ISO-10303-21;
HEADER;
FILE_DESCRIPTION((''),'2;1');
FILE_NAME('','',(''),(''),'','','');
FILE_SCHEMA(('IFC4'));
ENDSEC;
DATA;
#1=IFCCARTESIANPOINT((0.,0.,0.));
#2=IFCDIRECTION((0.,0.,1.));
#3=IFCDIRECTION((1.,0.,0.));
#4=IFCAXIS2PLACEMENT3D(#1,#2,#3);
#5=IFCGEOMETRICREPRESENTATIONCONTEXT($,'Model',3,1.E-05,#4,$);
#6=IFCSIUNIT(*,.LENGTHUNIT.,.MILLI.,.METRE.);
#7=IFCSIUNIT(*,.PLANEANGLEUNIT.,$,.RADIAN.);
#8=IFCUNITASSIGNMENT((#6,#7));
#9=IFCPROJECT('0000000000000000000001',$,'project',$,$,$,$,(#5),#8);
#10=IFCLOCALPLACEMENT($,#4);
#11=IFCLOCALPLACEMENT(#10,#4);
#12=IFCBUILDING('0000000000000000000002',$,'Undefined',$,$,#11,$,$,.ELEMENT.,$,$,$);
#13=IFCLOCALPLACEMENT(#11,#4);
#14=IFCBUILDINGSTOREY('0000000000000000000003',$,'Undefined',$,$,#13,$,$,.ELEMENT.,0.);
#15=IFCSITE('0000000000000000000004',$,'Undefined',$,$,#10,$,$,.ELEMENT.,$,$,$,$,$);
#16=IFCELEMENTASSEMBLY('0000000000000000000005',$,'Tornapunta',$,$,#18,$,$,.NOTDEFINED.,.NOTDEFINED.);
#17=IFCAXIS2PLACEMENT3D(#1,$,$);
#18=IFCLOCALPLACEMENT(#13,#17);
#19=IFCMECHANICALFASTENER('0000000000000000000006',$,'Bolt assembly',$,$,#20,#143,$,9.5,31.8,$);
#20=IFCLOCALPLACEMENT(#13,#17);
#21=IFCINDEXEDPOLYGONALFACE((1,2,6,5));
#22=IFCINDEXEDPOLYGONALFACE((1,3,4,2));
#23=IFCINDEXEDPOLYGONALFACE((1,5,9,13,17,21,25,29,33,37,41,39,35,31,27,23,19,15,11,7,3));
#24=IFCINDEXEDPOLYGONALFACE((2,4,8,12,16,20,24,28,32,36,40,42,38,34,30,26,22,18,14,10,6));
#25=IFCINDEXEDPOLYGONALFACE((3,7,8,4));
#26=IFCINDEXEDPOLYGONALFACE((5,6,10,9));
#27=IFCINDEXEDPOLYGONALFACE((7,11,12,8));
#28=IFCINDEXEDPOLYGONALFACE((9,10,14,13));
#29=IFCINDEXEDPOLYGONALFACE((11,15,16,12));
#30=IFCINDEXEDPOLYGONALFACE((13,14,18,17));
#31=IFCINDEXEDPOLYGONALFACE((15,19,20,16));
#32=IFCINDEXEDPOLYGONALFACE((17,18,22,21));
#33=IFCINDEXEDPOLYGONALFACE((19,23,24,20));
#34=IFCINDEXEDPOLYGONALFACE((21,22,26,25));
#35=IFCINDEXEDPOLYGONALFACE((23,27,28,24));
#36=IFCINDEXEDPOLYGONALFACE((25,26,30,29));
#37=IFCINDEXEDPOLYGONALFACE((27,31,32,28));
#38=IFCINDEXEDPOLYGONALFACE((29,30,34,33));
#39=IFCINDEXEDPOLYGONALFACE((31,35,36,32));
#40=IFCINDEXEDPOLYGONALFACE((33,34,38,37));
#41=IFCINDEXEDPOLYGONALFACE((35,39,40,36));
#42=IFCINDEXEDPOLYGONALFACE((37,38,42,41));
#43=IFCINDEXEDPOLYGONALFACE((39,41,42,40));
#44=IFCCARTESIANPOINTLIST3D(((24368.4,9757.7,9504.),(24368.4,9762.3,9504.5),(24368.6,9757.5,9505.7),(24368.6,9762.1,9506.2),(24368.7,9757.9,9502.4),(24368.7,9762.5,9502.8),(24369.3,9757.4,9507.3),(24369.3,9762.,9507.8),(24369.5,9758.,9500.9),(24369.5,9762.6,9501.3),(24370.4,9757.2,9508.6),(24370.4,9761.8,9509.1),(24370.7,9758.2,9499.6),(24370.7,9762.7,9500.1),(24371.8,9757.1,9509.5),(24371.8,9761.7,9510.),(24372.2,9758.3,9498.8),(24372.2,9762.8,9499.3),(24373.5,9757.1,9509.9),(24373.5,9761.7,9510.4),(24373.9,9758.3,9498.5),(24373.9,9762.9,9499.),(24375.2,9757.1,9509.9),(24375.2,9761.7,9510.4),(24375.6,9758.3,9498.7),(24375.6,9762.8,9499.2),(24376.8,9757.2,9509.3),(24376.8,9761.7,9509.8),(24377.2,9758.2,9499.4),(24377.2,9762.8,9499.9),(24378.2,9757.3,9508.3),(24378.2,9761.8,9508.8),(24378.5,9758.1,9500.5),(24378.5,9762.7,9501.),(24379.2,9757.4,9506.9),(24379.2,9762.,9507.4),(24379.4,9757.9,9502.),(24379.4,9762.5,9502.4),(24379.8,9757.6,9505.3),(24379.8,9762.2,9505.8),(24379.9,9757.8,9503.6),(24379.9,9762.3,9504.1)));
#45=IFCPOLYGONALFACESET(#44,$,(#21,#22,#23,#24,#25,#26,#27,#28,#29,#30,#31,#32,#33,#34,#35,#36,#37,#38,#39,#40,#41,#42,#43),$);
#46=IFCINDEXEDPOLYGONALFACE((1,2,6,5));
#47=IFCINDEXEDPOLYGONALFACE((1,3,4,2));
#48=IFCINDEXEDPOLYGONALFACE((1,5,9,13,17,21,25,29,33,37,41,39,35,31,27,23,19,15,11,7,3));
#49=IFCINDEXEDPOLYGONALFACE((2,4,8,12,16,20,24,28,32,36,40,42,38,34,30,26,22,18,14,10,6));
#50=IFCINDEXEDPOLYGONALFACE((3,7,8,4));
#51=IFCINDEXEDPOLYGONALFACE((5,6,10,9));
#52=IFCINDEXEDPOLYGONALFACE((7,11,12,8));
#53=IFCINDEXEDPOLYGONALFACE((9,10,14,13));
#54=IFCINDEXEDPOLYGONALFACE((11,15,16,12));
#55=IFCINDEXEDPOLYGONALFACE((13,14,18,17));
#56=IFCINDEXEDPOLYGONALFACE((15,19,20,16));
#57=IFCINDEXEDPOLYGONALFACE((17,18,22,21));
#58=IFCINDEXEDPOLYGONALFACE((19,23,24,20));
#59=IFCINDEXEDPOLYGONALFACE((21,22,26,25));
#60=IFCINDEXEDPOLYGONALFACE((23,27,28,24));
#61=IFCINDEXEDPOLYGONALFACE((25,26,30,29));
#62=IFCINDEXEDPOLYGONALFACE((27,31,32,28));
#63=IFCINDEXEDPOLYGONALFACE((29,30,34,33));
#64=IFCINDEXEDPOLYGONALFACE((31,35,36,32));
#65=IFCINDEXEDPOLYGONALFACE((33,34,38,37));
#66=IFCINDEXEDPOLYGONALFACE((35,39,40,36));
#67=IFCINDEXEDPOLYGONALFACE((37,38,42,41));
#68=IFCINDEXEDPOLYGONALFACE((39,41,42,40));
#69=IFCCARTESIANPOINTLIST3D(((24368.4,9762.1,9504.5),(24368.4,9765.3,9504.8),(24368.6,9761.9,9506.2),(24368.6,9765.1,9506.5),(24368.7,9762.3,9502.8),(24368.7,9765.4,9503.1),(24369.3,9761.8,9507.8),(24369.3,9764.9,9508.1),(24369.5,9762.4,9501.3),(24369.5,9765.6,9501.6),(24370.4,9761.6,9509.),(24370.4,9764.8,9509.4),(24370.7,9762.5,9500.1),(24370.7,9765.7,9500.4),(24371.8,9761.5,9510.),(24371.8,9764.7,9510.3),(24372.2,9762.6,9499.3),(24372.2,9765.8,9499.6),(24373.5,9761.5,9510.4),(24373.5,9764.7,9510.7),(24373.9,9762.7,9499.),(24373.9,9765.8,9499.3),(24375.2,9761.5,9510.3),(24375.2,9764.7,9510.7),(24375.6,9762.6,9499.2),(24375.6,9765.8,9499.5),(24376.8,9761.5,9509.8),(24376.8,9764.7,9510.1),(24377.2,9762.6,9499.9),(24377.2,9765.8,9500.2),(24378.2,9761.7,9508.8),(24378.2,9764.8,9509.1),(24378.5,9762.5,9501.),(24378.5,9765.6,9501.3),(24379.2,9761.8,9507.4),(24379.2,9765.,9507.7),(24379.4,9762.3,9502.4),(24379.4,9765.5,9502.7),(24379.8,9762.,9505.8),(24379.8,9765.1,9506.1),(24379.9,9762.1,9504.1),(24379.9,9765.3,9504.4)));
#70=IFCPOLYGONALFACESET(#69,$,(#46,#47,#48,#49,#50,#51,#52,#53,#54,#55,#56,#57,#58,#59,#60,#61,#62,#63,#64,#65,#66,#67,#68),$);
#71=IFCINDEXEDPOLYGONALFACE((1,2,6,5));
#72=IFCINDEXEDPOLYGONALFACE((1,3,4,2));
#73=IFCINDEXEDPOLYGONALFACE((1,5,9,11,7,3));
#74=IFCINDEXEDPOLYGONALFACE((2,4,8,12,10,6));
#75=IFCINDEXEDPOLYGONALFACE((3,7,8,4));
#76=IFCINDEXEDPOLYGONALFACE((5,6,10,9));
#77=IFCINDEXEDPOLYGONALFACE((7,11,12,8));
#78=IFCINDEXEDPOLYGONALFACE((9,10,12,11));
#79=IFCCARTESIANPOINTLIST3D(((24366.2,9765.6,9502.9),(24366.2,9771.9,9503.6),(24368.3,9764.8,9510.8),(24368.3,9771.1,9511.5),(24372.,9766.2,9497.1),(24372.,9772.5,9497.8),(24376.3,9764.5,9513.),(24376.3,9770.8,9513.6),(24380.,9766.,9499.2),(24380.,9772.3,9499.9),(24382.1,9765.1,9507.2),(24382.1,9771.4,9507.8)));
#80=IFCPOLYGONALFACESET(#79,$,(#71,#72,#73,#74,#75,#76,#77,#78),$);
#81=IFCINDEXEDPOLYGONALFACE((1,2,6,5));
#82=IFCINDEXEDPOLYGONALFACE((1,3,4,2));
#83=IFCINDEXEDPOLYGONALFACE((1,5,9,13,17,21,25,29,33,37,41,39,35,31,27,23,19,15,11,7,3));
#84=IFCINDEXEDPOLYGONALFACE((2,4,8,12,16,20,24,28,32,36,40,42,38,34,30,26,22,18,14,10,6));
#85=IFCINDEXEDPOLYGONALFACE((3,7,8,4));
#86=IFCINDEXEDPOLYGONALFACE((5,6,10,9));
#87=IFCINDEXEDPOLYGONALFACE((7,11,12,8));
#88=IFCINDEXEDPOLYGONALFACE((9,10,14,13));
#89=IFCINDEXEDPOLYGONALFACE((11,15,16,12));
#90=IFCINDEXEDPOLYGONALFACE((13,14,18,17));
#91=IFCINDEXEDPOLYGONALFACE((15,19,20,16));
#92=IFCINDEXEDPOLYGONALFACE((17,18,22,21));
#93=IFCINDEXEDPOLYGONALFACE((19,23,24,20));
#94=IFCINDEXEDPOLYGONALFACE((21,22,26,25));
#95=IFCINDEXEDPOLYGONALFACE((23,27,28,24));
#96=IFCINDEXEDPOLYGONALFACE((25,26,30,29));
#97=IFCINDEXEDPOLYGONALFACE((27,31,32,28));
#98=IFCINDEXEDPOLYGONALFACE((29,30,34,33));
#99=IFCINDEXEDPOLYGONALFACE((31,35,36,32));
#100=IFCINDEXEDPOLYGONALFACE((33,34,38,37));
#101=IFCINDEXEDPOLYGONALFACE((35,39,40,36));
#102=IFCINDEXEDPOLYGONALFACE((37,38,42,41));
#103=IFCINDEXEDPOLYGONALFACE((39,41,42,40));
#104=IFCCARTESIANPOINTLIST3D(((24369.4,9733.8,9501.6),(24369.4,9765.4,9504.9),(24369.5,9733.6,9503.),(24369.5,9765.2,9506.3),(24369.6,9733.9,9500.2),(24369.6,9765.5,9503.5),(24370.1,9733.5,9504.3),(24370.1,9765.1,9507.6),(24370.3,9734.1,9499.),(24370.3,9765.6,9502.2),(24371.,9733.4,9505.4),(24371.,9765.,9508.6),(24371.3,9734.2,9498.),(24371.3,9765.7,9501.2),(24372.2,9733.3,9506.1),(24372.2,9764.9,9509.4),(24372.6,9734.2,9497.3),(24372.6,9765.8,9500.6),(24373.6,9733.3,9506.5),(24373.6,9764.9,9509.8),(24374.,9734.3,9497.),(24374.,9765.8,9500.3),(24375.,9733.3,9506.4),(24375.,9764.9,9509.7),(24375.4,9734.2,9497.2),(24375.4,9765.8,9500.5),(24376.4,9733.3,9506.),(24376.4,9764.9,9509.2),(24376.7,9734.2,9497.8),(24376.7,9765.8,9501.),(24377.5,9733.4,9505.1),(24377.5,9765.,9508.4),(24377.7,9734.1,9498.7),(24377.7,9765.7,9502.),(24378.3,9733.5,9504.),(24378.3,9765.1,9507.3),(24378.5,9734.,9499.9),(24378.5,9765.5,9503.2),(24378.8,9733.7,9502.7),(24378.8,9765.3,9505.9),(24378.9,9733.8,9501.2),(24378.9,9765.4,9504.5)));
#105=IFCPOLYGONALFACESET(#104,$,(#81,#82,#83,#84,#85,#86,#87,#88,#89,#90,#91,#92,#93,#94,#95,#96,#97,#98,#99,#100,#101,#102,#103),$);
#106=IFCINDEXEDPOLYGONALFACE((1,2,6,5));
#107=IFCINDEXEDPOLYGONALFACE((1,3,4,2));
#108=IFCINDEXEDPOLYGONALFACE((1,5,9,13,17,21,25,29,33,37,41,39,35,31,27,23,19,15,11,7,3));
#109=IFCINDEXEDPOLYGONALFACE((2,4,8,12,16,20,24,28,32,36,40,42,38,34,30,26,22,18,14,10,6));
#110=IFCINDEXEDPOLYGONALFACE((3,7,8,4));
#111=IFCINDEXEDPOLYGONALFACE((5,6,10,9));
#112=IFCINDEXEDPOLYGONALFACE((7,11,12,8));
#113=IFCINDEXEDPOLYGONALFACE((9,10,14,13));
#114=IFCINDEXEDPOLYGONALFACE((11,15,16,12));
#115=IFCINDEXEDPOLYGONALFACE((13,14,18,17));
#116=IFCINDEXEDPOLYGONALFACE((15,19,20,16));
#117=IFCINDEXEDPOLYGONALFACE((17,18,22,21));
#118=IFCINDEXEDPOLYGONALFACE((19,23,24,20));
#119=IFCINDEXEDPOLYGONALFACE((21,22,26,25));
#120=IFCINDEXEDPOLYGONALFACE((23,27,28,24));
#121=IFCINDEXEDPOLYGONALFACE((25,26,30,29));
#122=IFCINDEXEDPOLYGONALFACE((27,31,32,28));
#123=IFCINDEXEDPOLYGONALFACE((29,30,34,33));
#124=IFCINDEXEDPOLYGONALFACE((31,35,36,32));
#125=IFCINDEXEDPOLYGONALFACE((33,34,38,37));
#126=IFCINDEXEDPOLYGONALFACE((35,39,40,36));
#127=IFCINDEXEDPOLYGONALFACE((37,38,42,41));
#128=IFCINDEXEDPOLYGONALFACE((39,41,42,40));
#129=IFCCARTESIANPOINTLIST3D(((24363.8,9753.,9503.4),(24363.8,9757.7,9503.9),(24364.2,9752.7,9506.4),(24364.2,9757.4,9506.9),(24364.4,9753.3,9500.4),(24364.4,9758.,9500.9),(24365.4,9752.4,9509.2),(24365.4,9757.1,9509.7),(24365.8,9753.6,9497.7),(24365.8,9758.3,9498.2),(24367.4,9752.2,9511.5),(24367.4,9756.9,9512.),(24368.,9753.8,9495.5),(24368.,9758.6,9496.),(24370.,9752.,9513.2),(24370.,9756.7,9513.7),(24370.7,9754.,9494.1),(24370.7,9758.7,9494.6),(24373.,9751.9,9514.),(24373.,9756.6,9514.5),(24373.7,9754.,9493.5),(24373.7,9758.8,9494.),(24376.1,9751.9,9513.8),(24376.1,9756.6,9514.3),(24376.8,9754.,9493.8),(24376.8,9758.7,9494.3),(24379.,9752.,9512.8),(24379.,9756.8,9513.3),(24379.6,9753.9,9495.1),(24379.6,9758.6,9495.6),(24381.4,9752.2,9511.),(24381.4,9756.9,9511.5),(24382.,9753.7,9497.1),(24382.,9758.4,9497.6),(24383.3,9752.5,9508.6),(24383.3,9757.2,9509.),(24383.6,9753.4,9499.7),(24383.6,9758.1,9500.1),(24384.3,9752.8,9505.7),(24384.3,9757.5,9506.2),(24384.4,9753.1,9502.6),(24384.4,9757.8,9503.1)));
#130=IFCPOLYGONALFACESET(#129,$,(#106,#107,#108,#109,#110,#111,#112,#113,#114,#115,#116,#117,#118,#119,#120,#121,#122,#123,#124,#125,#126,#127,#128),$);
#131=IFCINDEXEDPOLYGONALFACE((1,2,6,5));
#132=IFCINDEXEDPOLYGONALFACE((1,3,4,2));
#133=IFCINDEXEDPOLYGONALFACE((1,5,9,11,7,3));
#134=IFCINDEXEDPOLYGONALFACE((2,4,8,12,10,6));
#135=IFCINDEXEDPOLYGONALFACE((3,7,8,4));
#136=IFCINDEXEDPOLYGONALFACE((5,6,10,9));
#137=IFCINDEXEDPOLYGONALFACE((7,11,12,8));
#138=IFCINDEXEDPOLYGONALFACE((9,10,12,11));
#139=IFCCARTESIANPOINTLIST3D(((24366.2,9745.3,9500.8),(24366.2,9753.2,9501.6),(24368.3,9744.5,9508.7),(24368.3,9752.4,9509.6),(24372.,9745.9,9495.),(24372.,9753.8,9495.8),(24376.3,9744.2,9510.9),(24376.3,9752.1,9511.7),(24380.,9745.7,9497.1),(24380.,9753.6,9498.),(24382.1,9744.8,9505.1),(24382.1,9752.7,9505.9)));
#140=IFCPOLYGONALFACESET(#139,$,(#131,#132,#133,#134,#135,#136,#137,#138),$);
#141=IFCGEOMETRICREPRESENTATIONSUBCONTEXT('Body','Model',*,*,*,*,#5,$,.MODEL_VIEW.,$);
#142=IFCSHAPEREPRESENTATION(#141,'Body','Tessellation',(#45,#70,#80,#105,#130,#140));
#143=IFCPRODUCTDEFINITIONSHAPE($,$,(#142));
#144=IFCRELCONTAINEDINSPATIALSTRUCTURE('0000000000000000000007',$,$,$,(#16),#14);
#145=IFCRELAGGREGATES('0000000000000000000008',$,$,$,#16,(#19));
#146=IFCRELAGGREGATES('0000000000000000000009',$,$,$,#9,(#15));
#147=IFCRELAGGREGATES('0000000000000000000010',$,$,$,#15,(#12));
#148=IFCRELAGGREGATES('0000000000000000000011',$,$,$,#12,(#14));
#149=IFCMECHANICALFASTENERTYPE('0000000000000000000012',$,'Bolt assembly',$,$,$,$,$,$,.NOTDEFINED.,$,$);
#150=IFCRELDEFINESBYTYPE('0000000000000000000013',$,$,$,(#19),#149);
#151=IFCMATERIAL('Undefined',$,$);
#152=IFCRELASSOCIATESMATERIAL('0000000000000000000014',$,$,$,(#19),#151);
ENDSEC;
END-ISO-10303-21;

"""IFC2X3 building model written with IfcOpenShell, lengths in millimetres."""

from ifc_helpers import new_model, si_unit, frame, origin_with_axes, origin_2d_with_axis, place, context, subcontext, project, spatial, polyline, circle, outline, extrude, source, transform, mapped, material, type_object, element, aggregate, save


model = new_model("IFC2X3")

# Units and contexts
model_context = context("Model", 3, precision=1e-05, world=origin_with_axes())
body_context = subcontext(model_context, "Body", "Model", "MODEL_VIEW")
ifc_project = project(units=[si_unit("LENGTHUNIT", "METRE", prefix="MILLI"), si_unit("PLANEANGLEUNIT", "RADIAN")], contexts=[model_context])

# Site, building, storey
site_placement = place(None, origin_with_axes())
site = spatial("IfcSite", under=ifc_project, at=site_placement, Name="Undefined", CompositionType="ELEMENT")
building_placement = place(site_placement, origin_with_axes())
building = spatial("IfcBuilding", under=site, at=building_placement, Name="Undefined", CompositionType="ELEMENT")
storey_placement = place(building_placement, origin_with_axes())
storey = spatial("IfcBuildingStorey", under=building, at=storey_placement, Name="Undefined", CompositionType="ELEMENT", Elevation=0.0)

# Shared definitions
ifc_material_1 = material(Name="Undefined")
mechanical_fastener_type = type_object("IfcMechanicalFastenerType", Name="Bolt assembly")

# Element assembly
assembly_1_placement = place(storey_placement, origin_with_axes())
assembly_1 = element("IfcElementAssembly", 1, at=assembly_1_placement, inside=storey, Name="Tornapunta", AssemblyPlace="NOTDEFINED", PredefinedType="NOTDEFINED")

# Mechanical fastener
shared_shape_1 = source(origin_with_axes(), body_context, "Body", "SweptSolid", [
    extrude(circle(Radius=5.8, at=origin_2d_with_axis()), frame((0.0, -0.1, 0.0), z_axis=(0.0, 1.0, 0.0), x_axis=(1.0, 0.0, 0.0)), (0.0, 0.0, 1.0), 4.6),
    extrude(circle(Radius=5.8, at=origin_2d_with_axis()), frame((0.0, -3.1, 0.0), z_axis=(0.0, 1.0, 0.0), x_axis=(1.0, 0.0, 0.0)), (0.0, 0.0, 1.0), 3.2),
    extrude(outline(polyline([(7.1, -4.1), (7.1, 4.1), (0.0, 8.2), (-7.1, 4.1), (-7.1, -4.1), (0.0, -8.2), (7.1, -4.1)])), frame((0.0, -9.5, 0.0), z_axis=(0.0, 1.0, 0.0), x_axis=(1.0, 0.0, 0.0)), (0.0, 0.0, 1.0), 6.3),
    extrude(circle(Radius=4.8, at=origin_2d_with_axis()), frame((0.0, -3.2, 0.0), z_axis=(0.0, 1.0, 0.0), x_axis=(1.0, 0.0, 0.0)), (0.0, 0.0, 1.0), 31.8),
    extrude(circle(Radius=10.3, at=origin_2d_with_axis()), frame((0.0, 4.5, 0.0), z_axis=(0.0, 1.0, 0.0), x_axis=(1.0, 0.0, 0.0)), (0.0, 0.0, 1.0), 4.8),
    extrude(outline(polyline([(7.1, -4.1), (7.1, 4.1), (0.0, 8.2), (-7.1, 4.1), (-7.1, -4.1), (0.0, -8.2), (7.1, -4.1)])), frame((0.0, 9.3, 0.0), z_axis=(0.0, 1.0, 0.0), x_axis=(1.0, 0.0, 0.0)), (0.0, 0.0, 1.0), 7.9),
])
mechanical_fastener_1_placement = place(assembly_1_placement, frame((24374.1, 9762.2, 9504.7), z_axis=(0.707107, 0.072947, -0.703334), x_axis=(0.707107, -0.072947, 0.703334)))
mechanical_fastener_1 = element("IfcMechanicalFastener", 2, at=mechanical_fastener_1_placement, type_object=mechanical_fastener_type, material=ifc_material_1, Name="Bolt assembly", NominalDiameter=9.5, NominalLength=31.8, context=body_context, shape_type="MappedRepresentation", body=[
    mapped(shared_shape_1, transform((0.0, 0.0, 0.0))),
])
aggregate(assembly_1, [mechanical_fastener_1])

save(model, "model.ifc")
